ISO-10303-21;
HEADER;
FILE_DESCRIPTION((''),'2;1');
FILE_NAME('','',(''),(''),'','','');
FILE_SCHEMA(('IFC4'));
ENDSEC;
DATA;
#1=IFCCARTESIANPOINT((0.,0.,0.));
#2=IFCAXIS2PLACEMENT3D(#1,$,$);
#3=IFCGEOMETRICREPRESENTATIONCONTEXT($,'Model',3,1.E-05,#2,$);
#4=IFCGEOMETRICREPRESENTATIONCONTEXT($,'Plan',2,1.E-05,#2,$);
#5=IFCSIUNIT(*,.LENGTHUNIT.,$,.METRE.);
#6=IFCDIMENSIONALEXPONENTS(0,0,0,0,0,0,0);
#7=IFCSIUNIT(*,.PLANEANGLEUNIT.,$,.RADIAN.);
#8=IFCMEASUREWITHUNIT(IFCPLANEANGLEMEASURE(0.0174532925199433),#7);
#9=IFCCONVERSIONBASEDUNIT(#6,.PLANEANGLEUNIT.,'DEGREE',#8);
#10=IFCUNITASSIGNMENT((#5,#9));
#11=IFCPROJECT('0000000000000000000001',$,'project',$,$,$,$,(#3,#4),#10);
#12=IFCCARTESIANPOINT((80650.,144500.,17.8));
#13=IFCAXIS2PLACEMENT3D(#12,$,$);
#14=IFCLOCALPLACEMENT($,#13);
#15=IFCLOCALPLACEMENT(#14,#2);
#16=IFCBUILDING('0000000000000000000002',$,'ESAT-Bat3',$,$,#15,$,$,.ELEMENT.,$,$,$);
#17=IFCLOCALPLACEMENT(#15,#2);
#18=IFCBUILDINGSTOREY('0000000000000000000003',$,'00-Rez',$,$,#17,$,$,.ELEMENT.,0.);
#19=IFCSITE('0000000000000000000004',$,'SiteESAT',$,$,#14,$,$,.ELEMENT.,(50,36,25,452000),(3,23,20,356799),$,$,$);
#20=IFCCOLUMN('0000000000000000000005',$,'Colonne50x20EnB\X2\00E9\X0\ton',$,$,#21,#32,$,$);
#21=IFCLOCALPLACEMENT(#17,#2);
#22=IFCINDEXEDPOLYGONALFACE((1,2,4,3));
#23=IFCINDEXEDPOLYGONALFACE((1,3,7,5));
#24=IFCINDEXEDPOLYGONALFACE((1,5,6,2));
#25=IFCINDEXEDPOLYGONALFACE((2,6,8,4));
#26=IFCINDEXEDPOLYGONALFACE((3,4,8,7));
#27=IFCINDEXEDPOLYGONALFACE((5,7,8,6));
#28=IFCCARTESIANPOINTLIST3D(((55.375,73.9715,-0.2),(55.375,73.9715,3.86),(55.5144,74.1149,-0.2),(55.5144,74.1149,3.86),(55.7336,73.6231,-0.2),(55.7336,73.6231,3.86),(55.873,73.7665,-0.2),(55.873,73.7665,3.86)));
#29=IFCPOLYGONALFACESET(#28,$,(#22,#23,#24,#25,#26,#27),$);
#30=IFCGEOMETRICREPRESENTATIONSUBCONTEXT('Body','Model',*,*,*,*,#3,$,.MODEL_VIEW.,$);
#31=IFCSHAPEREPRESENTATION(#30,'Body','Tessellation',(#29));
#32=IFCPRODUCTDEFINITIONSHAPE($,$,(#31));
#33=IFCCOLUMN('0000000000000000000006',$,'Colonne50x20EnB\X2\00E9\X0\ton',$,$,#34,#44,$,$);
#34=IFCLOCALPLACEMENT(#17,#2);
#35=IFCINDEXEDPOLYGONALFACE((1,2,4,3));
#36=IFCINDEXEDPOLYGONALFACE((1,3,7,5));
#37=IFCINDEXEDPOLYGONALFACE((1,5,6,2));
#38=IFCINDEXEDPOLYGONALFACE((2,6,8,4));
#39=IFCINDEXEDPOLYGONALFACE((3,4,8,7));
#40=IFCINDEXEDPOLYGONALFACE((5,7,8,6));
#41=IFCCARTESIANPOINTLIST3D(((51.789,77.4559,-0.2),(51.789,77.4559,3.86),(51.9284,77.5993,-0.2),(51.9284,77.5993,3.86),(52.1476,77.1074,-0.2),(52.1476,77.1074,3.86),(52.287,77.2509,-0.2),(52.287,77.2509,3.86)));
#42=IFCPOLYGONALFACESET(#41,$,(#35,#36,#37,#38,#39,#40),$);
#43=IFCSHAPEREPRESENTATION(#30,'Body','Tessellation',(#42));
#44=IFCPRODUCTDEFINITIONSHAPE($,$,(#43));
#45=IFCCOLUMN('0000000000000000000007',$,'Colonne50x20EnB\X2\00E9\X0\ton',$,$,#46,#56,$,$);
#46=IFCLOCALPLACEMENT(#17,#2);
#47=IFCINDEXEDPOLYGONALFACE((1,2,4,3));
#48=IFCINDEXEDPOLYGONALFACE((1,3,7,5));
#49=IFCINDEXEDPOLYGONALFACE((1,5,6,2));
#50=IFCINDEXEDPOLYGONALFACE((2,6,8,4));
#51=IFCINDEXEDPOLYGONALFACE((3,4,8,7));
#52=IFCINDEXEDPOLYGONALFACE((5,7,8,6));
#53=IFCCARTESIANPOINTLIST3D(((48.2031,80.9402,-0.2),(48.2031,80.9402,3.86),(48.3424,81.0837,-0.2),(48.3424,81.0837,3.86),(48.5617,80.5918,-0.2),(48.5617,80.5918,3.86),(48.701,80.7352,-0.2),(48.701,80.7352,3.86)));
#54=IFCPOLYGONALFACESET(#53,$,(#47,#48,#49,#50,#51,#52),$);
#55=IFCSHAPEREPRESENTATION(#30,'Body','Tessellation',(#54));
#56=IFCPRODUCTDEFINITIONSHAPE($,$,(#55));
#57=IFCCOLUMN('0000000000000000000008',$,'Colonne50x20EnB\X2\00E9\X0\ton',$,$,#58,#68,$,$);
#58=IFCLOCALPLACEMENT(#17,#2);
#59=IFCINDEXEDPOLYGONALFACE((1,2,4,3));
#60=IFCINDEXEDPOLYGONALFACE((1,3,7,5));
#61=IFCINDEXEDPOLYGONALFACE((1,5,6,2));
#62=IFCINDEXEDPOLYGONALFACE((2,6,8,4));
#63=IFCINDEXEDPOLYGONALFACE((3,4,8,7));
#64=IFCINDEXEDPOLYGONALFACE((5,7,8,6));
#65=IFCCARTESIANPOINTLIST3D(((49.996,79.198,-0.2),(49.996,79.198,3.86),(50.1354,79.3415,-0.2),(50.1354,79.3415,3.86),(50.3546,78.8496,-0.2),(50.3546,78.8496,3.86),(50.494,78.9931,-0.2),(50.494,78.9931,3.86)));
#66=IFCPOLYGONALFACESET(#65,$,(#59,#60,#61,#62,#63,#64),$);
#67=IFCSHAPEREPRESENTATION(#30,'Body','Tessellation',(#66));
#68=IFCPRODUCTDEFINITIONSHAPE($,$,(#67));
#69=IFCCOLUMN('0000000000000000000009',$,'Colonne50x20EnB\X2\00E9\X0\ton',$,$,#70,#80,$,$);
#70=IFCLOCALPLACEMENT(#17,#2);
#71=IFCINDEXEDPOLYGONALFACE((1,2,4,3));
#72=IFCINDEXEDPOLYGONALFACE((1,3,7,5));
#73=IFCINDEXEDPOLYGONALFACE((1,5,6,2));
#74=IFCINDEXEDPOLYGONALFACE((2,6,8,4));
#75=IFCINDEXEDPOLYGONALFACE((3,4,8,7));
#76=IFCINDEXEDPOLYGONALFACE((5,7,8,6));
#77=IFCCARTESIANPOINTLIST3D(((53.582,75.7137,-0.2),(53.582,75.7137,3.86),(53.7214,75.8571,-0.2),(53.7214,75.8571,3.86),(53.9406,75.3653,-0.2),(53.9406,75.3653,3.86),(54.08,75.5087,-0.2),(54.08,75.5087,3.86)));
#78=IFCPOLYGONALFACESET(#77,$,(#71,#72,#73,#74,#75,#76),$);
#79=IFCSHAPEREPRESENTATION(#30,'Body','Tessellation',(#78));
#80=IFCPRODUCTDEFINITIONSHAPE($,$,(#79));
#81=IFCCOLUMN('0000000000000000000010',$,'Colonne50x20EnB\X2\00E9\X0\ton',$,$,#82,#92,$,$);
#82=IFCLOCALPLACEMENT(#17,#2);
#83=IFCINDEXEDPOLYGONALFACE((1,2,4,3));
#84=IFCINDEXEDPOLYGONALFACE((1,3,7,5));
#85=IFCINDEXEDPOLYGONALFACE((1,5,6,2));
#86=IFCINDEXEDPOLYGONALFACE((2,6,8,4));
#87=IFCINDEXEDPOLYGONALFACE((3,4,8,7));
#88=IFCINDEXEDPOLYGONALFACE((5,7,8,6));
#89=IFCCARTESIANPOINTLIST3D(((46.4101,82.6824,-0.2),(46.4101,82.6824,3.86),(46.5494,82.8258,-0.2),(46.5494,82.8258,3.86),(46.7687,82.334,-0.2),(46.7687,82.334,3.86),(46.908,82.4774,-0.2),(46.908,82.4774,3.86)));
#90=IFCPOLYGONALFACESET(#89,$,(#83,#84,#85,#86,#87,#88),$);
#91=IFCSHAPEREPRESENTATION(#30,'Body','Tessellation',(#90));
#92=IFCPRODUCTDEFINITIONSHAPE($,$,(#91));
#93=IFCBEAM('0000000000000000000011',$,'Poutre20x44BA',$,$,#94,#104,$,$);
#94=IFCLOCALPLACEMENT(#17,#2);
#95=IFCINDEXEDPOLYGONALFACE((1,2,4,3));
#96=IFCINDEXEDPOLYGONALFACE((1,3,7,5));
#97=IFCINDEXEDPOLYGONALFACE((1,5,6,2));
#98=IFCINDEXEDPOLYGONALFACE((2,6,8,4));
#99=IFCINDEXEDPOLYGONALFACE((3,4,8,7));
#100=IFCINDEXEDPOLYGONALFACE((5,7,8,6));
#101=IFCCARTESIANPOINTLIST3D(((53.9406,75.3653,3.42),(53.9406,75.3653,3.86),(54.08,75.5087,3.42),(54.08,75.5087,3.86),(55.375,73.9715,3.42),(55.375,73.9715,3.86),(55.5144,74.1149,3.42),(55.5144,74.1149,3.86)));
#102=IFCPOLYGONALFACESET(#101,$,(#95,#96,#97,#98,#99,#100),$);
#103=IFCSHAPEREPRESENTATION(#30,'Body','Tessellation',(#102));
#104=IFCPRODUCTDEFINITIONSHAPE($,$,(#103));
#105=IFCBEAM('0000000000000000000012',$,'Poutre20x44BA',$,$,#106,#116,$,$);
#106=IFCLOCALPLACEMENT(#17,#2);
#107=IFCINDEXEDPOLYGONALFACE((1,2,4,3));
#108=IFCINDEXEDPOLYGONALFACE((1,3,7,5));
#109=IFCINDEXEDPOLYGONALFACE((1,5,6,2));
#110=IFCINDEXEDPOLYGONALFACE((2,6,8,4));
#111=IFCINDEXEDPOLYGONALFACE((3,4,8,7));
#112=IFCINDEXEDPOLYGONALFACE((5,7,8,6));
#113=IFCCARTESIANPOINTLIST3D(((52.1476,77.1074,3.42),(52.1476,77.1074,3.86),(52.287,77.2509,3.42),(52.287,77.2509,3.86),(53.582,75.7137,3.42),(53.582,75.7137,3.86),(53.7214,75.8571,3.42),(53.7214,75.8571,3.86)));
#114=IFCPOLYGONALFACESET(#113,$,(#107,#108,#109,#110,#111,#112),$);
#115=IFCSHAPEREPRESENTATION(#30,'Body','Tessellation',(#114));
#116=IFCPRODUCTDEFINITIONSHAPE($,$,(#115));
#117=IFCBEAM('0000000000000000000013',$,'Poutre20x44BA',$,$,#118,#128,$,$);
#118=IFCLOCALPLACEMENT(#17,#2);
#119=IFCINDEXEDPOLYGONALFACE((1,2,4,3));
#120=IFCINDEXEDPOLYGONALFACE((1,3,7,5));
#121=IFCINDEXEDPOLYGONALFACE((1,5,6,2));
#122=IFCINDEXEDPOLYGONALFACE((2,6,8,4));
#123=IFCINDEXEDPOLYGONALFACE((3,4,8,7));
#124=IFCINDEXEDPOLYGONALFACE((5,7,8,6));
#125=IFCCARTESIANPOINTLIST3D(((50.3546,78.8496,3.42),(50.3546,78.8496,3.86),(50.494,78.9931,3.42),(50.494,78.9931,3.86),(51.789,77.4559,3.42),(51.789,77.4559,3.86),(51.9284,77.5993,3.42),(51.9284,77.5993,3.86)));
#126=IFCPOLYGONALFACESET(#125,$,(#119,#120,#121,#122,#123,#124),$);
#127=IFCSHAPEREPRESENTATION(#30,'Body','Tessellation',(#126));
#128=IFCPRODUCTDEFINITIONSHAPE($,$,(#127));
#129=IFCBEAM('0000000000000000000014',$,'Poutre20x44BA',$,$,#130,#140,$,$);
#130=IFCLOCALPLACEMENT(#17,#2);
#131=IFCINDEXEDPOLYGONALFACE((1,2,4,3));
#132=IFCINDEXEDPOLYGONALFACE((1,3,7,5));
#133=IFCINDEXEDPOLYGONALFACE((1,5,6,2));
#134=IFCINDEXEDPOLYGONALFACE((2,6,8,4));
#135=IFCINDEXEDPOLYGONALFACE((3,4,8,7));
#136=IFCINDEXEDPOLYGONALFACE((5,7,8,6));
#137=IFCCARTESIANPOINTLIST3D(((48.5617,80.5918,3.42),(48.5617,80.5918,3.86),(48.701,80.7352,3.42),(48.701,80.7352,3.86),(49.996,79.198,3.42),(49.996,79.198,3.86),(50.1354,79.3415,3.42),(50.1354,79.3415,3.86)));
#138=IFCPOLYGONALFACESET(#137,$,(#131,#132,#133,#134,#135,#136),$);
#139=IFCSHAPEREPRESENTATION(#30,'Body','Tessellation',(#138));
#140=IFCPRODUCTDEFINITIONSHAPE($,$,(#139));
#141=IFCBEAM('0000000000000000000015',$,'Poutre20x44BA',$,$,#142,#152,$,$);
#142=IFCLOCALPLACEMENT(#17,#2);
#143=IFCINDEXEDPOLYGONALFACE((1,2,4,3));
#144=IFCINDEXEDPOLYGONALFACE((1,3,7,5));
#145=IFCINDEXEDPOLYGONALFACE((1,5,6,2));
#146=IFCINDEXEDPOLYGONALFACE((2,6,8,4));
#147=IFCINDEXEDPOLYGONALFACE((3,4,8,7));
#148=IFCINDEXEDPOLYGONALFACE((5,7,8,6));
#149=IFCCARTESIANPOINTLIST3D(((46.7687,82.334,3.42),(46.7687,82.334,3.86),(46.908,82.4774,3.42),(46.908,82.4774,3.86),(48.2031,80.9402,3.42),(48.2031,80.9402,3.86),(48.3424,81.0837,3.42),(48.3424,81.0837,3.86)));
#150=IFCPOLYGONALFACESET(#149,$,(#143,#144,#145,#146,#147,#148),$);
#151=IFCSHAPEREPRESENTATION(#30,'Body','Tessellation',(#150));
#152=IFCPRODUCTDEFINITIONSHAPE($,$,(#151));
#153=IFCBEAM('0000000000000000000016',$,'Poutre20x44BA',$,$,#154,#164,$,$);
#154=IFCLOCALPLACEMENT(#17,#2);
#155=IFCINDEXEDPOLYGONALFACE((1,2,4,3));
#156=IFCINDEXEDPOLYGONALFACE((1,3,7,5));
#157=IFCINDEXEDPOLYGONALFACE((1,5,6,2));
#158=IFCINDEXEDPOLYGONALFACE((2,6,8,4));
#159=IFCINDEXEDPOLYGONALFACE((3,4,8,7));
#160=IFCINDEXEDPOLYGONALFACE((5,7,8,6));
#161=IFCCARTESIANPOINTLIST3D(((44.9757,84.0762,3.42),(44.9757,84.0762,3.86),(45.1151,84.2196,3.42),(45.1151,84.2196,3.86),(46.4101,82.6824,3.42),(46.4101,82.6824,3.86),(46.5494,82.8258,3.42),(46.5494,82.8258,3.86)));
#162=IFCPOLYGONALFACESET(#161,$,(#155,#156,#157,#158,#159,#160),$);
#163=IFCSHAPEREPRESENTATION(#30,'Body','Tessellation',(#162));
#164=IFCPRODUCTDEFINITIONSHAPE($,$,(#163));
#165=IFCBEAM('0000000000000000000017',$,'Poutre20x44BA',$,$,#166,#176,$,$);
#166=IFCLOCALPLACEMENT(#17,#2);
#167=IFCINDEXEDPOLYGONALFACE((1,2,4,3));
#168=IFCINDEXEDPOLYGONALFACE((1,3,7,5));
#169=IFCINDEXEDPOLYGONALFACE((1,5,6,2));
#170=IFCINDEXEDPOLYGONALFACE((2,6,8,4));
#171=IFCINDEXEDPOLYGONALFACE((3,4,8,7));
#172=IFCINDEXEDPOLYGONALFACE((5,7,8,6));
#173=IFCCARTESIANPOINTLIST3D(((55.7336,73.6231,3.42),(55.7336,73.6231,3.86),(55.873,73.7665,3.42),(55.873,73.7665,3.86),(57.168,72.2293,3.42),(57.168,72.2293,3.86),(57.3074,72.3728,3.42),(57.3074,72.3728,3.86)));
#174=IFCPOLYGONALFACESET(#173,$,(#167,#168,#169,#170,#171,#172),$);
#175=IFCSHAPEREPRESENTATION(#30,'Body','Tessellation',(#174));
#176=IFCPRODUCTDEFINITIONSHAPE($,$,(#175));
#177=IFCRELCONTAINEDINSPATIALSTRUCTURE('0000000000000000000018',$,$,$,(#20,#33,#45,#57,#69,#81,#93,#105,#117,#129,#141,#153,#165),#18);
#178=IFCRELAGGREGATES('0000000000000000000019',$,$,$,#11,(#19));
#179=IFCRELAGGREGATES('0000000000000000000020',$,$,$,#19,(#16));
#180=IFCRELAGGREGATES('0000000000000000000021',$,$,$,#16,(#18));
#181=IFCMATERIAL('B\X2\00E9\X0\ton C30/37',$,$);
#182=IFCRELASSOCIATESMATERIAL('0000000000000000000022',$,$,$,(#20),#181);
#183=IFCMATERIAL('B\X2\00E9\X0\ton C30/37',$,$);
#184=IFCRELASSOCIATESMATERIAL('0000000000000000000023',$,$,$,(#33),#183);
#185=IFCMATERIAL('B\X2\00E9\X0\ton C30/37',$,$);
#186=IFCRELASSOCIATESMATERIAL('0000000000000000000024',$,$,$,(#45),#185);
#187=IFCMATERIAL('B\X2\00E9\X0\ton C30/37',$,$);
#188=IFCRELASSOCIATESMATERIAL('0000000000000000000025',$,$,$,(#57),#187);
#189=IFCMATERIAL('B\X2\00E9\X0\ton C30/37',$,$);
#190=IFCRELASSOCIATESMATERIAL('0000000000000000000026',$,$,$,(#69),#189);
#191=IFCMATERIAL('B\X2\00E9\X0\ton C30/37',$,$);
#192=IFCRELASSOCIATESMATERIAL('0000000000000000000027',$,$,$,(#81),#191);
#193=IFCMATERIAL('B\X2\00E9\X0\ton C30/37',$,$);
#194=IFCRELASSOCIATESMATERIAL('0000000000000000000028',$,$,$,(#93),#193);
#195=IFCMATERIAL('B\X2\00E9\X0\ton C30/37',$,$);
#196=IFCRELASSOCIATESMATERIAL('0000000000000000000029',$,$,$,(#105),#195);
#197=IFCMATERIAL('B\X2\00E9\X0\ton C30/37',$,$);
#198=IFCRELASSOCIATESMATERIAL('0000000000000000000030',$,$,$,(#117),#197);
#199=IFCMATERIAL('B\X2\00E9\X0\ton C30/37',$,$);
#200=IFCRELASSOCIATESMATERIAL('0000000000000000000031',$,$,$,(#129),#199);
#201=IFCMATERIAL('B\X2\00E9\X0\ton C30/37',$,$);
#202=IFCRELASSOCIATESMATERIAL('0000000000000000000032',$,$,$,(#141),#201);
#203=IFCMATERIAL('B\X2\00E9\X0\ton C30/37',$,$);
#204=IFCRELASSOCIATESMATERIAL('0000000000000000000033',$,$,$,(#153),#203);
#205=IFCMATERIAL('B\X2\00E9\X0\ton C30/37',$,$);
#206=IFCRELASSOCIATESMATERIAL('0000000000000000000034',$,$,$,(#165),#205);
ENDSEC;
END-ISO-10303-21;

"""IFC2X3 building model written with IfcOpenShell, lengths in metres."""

from ifc_helpers import new_model, entity, si_unit, converted_unit, frame, frame_2d, origin, origin_with_axes, place, context, subcontext, project, spatial, rectangle, extrude, material, element, save


model = new_model("IFC2X3")

# Units and contexts
model_context = context("Model", 3, precision=1e-05, world=origin())
plan_context = context("Plan", 2, precision=1e-05, world=origin())
body_context = subcontext(model_context, "Body", "Model", "MODEL_VIEW")
ifc_project = project(units=[si_unit("LENGTHUNIT", "METRE"), converted_unit("PLANEANGLEUNIT", "DEGREE", entity("IfcPlaneAngleMeasure", 0.0174532925199433), si_unit("PLANEANGLEUNIT", "RADIAN"), dimensions=[0, 0, 0, 0, 0, 0, 0])], contexts=[model_context, plan_context])

# Site, building, storey
site_placement = place(None, frame((80650.0, 144500.0, 17.8)))
site = spatial("IfcSite", under=ifc_project, at=site_placement, Name="SiteESAT", CompositionType="ELEMENT", RefLatitude=(50, 36, 25, 452000), RefLongitude=(3, 23, 20, 356799))
building_placement = place(site_placement, origin())
building = spatial("IfcBuilding", under=site, at=building_placement, Name="ESAT-Bat3", CompositionType="ELEMENT")
storey_placement = place(building_placement, origin())
storey = spatial("IfcBuildingStorey", under=building, at=storey_placement, Name="00-Rez", CompositionType="ELEMENT", Elevation=0.0)

# Columns
ifc_material_1 = material(Name="Béton C30/37")
column_1_placement = place(storey_placement, frame((55.873, 73.7665, -0.2)))
element("IfcColumn", 1, at=column_1_placement, inside=storey, material=ifc_material_1, Name="Colonne50x20EnBéton", context=body_context, shape_type="SweptSolid", body=[
    extrude(rectangle(XDim=0.5, YDim=0.2, at=frame_2d((-0.249, 0.1025), x_axis=(-0.717196, 0.696872))), origin_with_axes(), (0.0, 0.0, 1.0), 4.06),
])
ifc_material_2 = material(Name="Béton C30/37")
column_2_placement = place(storey_placement, frame((52.287, 77.2509, -0.2)))
element("IfcColumn", 2, at=column_2_placement, inside=storey, material=ifc_material_2, Name="Colonne50x20EnBéton", context=body_context, shape_type="SweptSolid", body=[
    extrude(rectangle(XDim=0.5, YDim=0.2, at=frame_2d((-0.249, 0.1025), x_axis=(-0.717196, 0.696872))), origin_with_axes(), (0.0, 0.0, 1.0), 4.06),
])
ifc_material_3 = material(Name="Béton C30/37")
column_3_placement = place(storey_placement, frame((48.701, 80.7352, -0.2)))
element("IfcColumn", 3, at=column_3_placement, inside=storey, material=ifc_material_3, Name="Colonne50x20EnBéton", context=body_context, shape_type="SweptSolid", body=[
    extrude(rectangle(XDim=0.5, YDim=0.2, at=frame_2d((-0.249, 0.1025), x_axis=(-0.717196, 0.696872))), origin_with_axes(), (0.0, 0.0, 1.0), 4.06),
])
ifc_material_4 = material(Name="Béton C30/37")
column_4_placement = place(storey_placement, frame((50.494, 78.9931, -0.2)))
element("IfcColumn", 4, at=column_4_placement, inside=storey, material=ifc_material_4, Name="Colonne50x20EnBéton", context=body_context, shape_type="SweptSolid", body=[
    extrude(rectangle(XDim=0.5, YDim=0.2, at=frame_2d((-0.249, 0.1025), x_axis=(-0.717196, 0.696872))), origin_with_axes(), (0.0, 0.0, 1.0), 4.06),
])
ifc_material_5 = material(Name="Béton C30/37")
column_5_placement = place(storey_placement, frame((54.08, 75.5087, -0.2)))
element("IfcColumn", 5, at=column_5_placement, inside=storey, material=ifc_material_5, Name="Colonne50x20EnBéton", context=body_context, shape_type="SweptSolid", body=[
    extrude(rectangle(XDim=0.5, YDim=0.2, at=frame_2d((-0.249, 0.1025), x_axis=(-0.717196, 0.696872))), origin_with_axes(), (0.0, 0.0, 1.0), 4.06),
])
ifc_material_6 = material(Name="Béton C30/37")
column_6_placement = place(storey_placement, frame((46.908, 82.4774, -0.2)))
element("IfcColumn", 6, at=column_6_placement, inside=storey, material=ifc_material_6, Name="Colonne50x20EnBéton", context=body_context, shape_type="SweptSolid", body=[
    extrude(rectangle(XDim=0.5, YDim=0.2, at=frame_2d((-0.249, 0.1025), x_axis=(-0.717196, 0.696872))), origin_with_axes(), (0.0, 0.0, 1.0), 4.06),
])

# Beams
ifc_material_7 = material(Name="Béton C30/37")
beam_1_placement = place(storey_placement, frame((55.5144, 74.1149, 3.42), z_axis=(0.0, 0.0, 1.0), x_axis=(-0.717196, 0.696872, 0.0)))
element("IfcBeam", 7, at=beam_1_placement, inside=storey, material=ifc_material_7, Name="Poutre20x44BA", context=body_context, shape_type="SweptSolid", body=[
    extrude(rectangle(XDim=0.2, YDim=0.44, at=frame_2d((0.1, 0.22), x_axis=(1.0, 0.0))), frame((0.0, 0.0, 0.0), z_axis=(1.0, 0.0, 0.0), x_axis=(0.0, 1.0, 0.0)), (0.0, 0.0, 1.0), 2.0),
])
ifc_material_8 = material(Name="Béton C30/37")
beam_2_placement = place(storey_placement, frame((53.7214, 75.8571, 3.42), z_axis=(0.0, 0.0, 1.0), x_axis=(-0.717196, 0.696872, 0.0)))
element("IfcBeam", 8, at=beam_2_placement, inside=storey, material=ifc_material_8, Name="Poutre20x44BA", context=body_context, shape_type="SweptSolid", body=[
    extrude(rectangle(XDim=0.2, YDim=0.44, at=frame_2d((0.1, 0.22), x_axis=(1.0, 0.0))), frame((0.0, 0.0, 0.0), z_axis=(1.0, 0.0, 0.0), x_axis=(0.0, 1.0, 0.0)), (0.0, 0.0, 1.0), 2.0),
])
ifc_material_9 = material(Name="Béton C30/37")
beam_3_placement = place(storey_placement, frame((51.9284, 77.5993, 3.42), z_axis=(0.0, 0.0, 1.0), x_axis=(-0.717196, 0.696872, 0.0)))
element("IfcBeam", 9, at=beam_3_placement, inside=storey, material=ifc_material_9, Name="Poutre20x44BA", context=body_context, shape_type="SweptSolid", body=[
    extrude(rectangle(XDim=0.2, YDim=0.44, at=frame_2d((0.1, 0.22), x_axis=(1.0, 0.0))), frame((0.0, 0.0, 0.0), z_axis=(1.0, 0.0, 0.0), x_axis=(0.0, 1.0, 0.0)), (0.0, 0.0, 1.0), 2.0),
])
ifc_material_10 = material(Name="Béton C30/37")
beam_4_placement = place(storey_placement, frame((50.1354, 79.3415, 3.42), z_axis=(0.0, 0.0, 1.0), x_axis=(-0.717196, 0.696872, 0.0)))
element("IfcBeam", 10, at=beam_4_placement, inside=storey, material=ifc_material_10, Name="Poutre20x44BA", context=body_context, shape_type="SweptSolid", body=[
    extrude(rectangle(XDim=0.2, YDim=0.44, at=frame_2d((0.1, 0.22), x_axis=(1.0, 0.0))), frame((0.0, 0.0, 0.0), z_axis=(1.0, 0.0, 0.0), x_axis=(0.0, 1.0, 0.0)), (0.0, 0.0, 1.0), 2.0),
])
ifc_material_11 = material(Name="Béton C30/37")
beam_5_placement = place(storey_placement, frame((48.3424, 81.0837, 3.42), z_axis=(0.0, 0.0, 1.0), x_axis=(-0.717196, 0.696872, 0.0)))
element("IfcBeam", 11, at=beam_5_placement, inside=storey, material=ifc_material_11, Name="Poutre20x44BA", context=body_context, shape_type="SweptSolid", body=[
    extrude(rectangle(XDim=0.2, YDim=0.44, at=frame_2d((0.1, 0.22), x_axis=(1.0, 0.0))), frame((0.0, 0.0, 0.0), z_axis=(1.0, 0.0, 0.0), x_axis=(0.0, 1.0, 0.0)), (0.0, 0.0, 1.0), 2.0),
])
ifc_material_12 = material(Name="Béton C30/37")
beam_6_placement = place(storey_placement, frame((46.5494, 82.8258, 3.42), z_axis=(0.0, 0.0, 1.0), x_axis=(-0.717196, 0.696872, 0.0)))
element("IfcBeam", 12, at=beam_6_placement, inside=storey, material=ifc_material_12, Name="Poutre20x44BA", context=body_context, shape_type="SweptSolid", body=[
    extrude(rectangle(XDim=0.2, YDim=0.44, at=frame_2d((0.1, 0.22), x_axis=(1.0, 0.0))), frame((0.0, 0.0, 0.0), z_axis=(1.0, 0.0, 0.0), x_axis=(0.0, 1.0, 0.0)), (0.0, 0.0, 1.0), 2.0),
])
ifc_material_13 = material(Name="Béton C30/37")
beam_7_placement = place(storey_placement, frame((57.3074, 72.3728, 3.42), z_axis=(0.0, 0.0, 1.0), x_axis=(-0.717196, 0.696872, 0.0)))
element("IfcBeam", 13, at=beam_7_placement, inside=storey, material=ifc_material_13, Name="Poutre20x44BA", context=body_context, shape_type="SweptSolid", body=[
    extrude(rectangle(XDim=0.2, YDim=0.44, at=frame_2d((0.1, 0.22), x_axis=(1.0, 0.0))), frame((0.0, 0.0, 0.0), z_axis=(1.0, 0.0, 0.0), x_axis=(0.0, 1.0, 0.0)), (0.0, 0.0, 1.0), 2.0),
])

save(model, "model.ifc")
